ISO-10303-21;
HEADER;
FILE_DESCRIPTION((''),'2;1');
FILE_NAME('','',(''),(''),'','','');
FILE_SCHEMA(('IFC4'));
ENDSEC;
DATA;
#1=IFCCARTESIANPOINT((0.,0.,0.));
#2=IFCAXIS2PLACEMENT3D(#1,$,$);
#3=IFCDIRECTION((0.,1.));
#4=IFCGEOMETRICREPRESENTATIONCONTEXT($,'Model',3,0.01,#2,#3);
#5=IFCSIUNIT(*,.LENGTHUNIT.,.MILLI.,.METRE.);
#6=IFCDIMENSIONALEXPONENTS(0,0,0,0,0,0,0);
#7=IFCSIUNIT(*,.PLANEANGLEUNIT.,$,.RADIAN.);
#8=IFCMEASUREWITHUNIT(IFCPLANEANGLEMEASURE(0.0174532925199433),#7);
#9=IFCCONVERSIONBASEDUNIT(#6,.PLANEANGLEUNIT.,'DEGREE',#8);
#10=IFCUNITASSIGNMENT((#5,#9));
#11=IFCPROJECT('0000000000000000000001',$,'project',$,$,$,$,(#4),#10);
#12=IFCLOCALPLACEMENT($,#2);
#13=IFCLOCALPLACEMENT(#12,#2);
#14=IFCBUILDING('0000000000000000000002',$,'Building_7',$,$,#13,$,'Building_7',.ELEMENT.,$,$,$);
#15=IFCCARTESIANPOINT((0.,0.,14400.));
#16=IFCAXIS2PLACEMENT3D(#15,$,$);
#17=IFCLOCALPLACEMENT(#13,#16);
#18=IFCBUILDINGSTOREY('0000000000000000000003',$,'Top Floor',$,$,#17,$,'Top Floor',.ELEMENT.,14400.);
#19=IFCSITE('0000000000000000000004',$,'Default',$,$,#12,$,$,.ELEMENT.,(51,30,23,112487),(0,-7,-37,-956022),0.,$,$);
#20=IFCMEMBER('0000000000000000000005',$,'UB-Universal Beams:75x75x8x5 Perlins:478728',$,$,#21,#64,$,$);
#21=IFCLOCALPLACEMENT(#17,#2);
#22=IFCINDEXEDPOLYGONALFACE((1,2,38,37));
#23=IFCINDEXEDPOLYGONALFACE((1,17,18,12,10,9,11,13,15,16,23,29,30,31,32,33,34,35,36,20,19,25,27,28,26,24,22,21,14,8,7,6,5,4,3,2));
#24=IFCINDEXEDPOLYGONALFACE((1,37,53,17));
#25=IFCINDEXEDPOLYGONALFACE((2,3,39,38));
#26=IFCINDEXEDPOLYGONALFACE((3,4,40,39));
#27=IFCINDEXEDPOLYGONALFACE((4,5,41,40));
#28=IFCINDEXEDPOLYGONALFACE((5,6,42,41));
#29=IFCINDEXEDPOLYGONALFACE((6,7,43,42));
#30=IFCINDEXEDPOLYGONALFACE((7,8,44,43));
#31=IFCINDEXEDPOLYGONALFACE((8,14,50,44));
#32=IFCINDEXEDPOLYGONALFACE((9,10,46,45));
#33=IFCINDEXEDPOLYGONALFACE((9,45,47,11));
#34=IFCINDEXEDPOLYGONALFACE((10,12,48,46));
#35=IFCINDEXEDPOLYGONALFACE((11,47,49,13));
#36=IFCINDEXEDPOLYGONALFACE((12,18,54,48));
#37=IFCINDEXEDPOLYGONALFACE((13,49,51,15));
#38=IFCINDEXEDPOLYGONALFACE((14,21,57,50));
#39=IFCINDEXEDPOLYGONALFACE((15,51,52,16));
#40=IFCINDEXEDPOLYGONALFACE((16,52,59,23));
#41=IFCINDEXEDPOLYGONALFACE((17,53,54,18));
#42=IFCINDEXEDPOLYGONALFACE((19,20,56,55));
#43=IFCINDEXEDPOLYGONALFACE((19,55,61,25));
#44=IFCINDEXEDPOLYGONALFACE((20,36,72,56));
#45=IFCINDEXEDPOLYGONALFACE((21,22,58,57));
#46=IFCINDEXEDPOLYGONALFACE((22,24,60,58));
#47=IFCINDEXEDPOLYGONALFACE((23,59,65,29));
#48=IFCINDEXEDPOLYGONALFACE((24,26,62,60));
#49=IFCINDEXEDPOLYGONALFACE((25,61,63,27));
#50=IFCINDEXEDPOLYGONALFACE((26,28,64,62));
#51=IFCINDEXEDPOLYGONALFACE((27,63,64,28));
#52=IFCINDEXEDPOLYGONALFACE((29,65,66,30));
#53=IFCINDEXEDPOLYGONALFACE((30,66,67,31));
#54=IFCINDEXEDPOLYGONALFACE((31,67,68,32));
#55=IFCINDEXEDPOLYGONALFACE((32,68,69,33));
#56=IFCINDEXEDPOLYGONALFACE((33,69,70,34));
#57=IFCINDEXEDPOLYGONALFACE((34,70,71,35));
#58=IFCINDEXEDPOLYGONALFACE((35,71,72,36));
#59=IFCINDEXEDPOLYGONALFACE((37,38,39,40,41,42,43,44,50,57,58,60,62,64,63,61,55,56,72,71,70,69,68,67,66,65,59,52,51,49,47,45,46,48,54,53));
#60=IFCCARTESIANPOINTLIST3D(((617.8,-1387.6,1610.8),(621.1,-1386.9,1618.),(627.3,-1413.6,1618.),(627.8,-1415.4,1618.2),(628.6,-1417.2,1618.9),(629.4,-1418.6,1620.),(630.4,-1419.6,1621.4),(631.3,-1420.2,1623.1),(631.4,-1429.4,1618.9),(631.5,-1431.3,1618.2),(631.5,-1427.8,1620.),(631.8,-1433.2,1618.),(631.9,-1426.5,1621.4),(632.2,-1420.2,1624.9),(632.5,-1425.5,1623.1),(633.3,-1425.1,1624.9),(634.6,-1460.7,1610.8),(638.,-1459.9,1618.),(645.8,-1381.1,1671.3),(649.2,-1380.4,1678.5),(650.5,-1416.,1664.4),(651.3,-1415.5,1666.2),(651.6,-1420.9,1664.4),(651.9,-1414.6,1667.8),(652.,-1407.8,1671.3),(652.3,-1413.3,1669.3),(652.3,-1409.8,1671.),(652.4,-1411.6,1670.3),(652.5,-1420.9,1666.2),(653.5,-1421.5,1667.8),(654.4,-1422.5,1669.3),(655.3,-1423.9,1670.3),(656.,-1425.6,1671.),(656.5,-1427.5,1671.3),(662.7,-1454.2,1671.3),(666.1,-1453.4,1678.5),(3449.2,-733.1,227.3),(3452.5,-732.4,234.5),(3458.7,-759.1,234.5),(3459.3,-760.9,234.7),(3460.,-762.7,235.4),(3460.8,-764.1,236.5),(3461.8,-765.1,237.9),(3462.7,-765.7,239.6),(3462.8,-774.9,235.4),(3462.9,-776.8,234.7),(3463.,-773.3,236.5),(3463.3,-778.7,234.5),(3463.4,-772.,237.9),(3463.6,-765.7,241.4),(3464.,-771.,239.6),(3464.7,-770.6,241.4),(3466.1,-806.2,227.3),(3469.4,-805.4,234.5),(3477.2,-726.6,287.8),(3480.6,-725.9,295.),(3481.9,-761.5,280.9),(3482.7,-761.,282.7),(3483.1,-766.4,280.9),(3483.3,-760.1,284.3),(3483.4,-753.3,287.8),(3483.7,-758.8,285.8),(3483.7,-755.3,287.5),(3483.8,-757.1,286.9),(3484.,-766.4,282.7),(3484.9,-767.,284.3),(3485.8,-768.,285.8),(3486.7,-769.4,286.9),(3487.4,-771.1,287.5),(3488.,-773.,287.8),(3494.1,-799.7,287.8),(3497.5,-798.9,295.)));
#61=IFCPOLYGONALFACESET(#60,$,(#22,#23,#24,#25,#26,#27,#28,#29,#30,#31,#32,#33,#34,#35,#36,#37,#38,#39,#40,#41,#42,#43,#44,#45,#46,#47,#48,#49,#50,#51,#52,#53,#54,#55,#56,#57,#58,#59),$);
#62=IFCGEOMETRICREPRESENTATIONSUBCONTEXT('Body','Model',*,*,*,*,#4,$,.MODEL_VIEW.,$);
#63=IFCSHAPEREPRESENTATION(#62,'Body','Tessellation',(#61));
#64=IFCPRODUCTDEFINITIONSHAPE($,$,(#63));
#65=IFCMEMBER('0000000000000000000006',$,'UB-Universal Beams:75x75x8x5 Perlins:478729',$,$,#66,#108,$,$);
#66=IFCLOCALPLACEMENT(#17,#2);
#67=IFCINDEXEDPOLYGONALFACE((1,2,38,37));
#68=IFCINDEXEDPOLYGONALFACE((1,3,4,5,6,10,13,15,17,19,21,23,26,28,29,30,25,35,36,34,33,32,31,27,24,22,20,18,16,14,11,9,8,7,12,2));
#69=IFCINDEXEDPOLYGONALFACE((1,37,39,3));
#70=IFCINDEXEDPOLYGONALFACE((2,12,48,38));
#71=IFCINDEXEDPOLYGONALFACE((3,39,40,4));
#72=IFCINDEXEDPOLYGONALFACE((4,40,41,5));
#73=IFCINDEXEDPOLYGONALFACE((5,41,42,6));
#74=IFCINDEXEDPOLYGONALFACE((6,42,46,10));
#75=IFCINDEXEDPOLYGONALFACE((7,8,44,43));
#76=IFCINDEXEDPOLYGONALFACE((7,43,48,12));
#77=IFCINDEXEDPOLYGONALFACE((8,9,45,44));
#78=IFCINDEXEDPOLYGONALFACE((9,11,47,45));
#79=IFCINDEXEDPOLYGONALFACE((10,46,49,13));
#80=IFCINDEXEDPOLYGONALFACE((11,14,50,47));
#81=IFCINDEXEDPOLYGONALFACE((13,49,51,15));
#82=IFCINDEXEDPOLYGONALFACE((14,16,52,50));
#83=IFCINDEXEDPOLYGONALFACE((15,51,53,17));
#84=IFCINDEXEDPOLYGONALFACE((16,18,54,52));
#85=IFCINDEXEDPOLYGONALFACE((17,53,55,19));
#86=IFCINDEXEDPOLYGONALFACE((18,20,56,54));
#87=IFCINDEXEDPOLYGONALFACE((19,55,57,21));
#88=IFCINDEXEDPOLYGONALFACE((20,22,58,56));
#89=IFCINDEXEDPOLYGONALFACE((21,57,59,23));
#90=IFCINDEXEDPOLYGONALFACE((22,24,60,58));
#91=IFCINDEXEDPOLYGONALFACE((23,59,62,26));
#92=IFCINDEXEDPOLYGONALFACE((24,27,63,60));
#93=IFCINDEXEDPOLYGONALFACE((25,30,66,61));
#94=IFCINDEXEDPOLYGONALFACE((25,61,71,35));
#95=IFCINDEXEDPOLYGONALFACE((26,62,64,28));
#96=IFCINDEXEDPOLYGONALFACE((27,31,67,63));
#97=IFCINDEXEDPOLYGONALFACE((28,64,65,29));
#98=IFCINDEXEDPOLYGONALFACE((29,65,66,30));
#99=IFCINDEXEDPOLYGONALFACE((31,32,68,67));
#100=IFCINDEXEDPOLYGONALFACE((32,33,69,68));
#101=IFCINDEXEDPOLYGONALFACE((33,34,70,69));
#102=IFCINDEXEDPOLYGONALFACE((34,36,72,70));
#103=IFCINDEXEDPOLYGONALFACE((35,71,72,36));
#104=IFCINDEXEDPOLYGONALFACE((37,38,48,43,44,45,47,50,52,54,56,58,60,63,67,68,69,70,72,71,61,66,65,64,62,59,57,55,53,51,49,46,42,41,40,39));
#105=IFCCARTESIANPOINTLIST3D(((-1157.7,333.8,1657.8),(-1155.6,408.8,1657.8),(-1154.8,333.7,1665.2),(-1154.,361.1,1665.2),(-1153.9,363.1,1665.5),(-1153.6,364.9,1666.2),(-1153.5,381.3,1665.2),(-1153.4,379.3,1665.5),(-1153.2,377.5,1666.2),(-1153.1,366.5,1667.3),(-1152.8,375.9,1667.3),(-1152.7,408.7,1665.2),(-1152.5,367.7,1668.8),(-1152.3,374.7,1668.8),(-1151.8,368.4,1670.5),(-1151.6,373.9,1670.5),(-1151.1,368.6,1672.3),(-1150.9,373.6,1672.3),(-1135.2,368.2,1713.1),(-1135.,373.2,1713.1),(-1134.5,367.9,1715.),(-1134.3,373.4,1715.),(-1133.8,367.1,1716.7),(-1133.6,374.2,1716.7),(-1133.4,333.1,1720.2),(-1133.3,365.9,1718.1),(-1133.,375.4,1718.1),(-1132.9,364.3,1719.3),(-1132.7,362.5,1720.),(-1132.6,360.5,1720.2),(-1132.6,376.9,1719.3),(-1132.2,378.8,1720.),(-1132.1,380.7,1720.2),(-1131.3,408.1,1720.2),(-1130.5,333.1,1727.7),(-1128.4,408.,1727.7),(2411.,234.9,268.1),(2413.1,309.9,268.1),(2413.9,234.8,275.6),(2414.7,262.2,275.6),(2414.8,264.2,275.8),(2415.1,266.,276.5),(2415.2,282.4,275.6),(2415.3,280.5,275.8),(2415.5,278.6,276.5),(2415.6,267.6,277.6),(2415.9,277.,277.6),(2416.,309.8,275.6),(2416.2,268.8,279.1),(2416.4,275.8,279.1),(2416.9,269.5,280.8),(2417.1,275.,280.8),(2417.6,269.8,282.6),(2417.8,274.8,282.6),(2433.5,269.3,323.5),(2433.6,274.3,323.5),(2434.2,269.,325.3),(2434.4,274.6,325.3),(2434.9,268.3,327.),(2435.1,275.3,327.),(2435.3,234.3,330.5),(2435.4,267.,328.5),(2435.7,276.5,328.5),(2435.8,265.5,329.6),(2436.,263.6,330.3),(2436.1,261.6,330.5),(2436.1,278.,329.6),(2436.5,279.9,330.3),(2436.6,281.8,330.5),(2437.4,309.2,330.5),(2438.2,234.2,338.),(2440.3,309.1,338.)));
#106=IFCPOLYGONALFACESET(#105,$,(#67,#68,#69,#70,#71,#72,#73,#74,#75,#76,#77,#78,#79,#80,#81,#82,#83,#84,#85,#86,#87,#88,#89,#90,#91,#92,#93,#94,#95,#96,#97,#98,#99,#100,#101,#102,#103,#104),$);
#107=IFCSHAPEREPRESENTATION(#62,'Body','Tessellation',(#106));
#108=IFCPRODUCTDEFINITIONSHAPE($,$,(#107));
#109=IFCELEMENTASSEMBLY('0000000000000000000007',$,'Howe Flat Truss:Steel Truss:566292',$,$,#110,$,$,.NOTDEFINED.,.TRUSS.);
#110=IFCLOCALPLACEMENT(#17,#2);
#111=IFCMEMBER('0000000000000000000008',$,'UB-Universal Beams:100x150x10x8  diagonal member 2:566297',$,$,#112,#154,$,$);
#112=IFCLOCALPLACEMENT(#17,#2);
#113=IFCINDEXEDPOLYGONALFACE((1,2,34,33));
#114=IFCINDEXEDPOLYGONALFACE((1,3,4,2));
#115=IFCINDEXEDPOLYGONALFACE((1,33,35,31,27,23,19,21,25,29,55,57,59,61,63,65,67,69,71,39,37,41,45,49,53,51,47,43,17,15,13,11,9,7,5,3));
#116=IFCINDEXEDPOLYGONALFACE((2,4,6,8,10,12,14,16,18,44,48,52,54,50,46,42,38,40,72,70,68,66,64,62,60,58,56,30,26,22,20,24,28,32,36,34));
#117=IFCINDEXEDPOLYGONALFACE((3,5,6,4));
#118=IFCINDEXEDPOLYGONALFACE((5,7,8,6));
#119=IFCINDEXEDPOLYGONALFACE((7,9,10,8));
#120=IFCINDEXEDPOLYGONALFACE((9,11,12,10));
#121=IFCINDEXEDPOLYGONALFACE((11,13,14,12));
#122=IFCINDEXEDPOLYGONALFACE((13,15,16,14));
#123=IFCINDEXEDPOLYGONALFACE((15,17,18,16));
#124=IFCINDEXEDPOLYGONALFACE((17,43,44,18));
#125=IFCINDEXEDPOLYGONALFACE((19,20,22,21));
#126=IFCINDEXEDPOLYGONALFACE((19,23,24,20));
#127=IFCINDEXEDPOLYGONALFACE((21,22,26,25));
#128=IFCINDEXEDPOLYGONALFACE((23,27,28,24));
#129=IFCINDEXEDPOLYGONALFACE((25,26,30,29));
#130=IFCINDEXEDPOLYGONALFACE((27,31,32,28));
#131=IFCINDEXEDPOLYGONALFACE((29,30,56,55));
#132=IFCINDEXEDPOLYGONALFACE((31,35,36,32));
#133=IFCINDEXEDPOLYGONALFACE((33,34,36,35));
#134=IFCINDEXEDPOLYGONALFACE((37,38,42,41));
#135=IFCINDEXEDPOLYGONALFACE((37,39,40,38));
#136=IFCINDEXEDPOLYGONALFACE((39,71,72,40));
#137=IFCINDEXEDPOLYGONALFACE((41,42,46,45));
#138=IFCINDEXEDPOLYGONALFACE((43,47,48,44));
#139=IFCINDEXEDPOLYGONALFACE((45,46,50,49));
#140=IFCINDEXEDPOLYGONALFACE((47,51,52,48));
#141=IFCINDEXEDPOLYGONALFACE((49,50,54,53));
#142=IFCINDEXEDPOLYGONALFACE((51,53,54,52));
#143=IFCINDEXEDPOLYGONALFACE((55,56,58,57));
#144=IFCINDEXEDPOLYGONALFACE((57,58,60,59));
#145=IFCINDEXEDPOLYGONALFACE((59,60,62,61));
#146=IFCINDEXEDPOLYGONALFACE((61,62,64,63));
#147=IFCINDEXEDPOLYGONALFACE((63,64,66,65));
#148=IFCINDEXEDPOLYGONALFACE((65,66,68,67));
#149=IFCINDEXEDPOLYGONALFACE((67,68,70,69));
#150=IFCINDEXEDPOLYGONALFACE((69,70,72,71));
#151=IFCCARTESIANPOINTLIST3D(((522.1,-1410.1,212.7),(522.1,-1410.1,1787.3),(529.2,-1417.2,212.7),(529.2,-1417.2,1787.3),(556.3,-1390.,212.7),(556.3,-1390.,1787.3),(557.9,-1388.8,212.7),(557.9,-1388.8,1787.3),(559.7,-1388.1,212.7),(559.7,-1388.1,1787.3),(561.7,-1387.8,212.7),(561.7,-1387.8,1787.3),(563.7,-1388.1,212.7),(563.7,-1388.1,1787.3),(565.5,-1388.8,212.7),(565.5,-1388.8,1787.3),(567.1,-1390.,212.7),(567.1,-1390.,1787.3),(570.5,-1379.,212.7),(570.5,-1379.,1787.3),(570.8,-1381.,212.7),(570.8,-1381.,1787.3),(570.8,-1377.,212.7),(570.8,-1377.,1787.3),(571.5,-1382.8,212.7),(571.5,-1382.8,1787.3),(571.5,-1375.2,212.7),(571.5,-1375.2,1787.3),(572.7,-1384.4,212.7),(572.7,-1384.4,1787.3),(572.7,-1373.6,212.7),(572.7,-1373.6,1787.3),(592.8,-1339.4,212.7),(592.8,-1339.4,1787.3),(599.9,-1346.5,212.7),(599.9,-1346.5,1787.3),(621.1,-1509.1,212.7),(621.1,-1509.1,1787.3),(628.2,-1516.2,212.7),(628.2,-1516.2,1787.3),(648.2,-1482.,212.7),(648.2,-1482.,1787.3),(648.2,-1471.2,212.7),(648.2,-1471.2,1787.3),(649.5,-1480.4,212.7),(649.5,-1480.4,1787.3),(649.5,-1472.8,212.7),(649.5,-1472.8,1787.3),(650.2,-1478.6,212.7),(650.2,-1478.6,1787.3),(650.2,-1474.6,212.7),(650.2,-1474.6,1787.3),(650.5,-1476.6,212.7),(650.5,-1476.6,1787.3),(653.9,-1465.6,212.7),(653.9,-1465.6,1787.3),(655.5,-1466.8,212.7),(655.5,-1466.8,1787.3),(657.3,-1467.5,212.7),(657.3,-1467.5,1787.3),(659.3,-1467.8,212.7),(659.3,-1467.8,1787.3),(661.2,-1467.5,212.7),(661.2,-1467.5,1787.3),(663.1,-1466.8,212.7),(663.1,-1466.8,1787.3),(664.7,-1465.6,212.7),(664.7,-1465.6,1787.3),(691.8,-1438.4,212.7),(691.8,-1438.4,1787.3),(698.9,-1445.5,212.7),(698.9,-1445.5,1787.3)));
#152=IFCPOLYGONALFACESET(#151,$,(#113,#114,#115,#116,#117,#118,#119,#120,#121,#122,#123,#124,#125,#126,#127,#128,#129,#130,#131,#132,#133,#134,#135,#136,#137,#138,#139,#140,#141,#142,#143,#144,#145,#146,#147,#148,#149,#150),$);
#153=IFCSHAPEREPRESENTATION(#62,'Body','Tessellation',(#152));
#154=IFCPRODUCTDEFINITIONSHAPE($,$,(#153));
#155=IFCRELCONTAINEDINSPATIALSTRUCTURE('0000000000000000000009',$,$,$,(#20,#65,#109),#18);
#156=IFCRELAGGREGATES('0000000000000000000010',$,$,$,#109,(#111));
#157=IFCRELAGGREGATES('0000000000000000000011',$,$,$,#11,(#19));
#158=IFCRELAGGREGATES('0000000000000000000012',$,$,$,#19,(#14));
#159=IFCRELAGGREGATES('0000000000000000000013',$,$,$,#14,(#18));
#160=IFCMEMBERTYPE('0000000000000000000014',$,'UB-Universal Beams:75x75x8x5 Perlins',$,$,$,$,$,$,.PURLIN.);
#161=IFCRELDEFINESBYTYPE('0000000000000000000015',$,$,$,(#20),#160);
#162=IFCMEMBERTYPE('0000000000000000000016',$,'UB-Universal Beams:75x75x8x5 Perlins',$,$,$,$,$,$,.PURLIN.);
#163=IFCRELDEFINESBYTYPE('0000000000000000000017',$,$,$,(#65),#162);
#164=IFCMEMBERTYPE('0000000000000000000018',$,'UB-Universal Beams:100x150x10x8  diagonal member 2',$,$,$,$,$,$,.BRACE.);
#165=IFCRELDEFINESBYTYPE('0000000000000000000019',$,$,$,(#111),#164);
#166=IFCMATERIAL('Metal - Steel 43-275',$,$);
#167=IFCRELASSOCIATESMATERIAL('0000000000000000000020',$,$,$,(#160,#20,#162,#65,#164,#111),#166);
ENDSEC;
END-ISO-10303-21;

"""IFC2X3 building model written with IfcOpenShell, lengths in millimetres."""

from ifc_helpers import new_model, entity, si_unit, converted_unit, direction, frame, frame_2d, origin, place, context, subcontext, project, spatial, polyline, circle_curve, parameter, trimmed, segment, composite_curve, outline, extrude, source, transform, mapped, material, type_object, type_shapes, element, aggregate, save


model = new_model("IFC2X3")

# Units and contexts
model_context = context("Model", 3, precision=0.01, world=origin(), true_north=direction((0.0, 1.0)))
body_context = subcontext(model_context, "Body", "Model", "MODEL_VIEW")
ifc_project = project(units=[si_unit("LENGTHUNIT", "METRE", prefix="MILLI"), converted_unit("PLANEANGLEUNIT", "DEGREE", entity("IfcPlaneAngleMeasure", 0.0174532925199433), si_unit("PLANEANGLEUNIT", "RADIAN"), dimensions=[0, 0, 0, 0, 0, 0, 0])], contexts=[model_context])

# Site, building, storey
site_placement = place(None, origin())
site = spatial("IfcSite", under=ifc_project, at=site_placement, Name="Default", CompositionType="ELEMENT", RefLatitude=(51, 30, 23, 112487), RefLongitude=(0, -7, -37, -956022), RefElevation=0.0)
building_placement = place(site_placement, origin())
building = spatial("IfcBuilding", under=site, at=building_placement, Name="Building_7", LongName="Building_7", CompositionType="ELEMENT")
storey_placement = place(building_placement, frame((0.0, 0.0, 14400.0)))
storey = spatial("IfcBuildingStorey", under=building, at=storey_placement, Name="Top Floor", LongName="Top Floor", CompositionType="ELEMENT", Elevation=14400.0)

# Members
ifc_material = material(Name="Metal - Steel 43-275")
member_type_1 = type_object("IfcMemberType", Name="UB-Universal Beams:75x75x8x5 Perlins", PredefinedType="PURLIN", material=ifc_material)
shared_shape_1 = source(origin(), body_context, "Body", "SweptSolid", [
    extrude(outline(composite_curve([segment(polyline([(-37.5, -29.5), (-37.5, -37.5)]), True, "CONTINUOUS"), segment(polyline([(-37.5, -37.5), (37.5, -37.5)]), True, "CONTINUOUS"), segment(polyline([(37.5, -37.5), (37.5, -29.5)]), True, "CONTINUOUS"), segment(polyline([(37.5, -29.5), (10.1, -29.5)]), True, "CONTINUOUS"), segment(trimmed(circle_curve(frame_2d((10.1, -21.9), x_axis=(1.0, 0.0)), 7.6), [parameter(180.0)], [parameter(270.0)], True, "PARAMETER"), False, "CONTINUOUS"), segment(polyline([(2.5, -21.9), (2.5, 21.9)]), True, "CONTINUOUS"), segment(trimmed(circle_curve(frame_2d((10.1, 21.9), x_axis=(1.0, 0.0)), 7.6), [parameter(90.0)], [parameter(180.0)], True, "PARAMETER"), False, "CONTINUOUS"), segment(polyline([(10.1, 29.5), (37.5, 29.5)]), True, "CONTINUOUS"), segment(polyline([(37.5, 29.5), (37.5, 37.5)]), True, "CONTINUOUS"), segment(polyline([(37.5, 37.5), (-37.5, 37.5)]), True, "CONTINUOUS"), segment(polyline([(-37.5, 37.5), (-37.5, 29.5)]), True, "CONTINUOUS"), segment(polyline([(-37.5, 29.5), (-10.1, 29.5)]), True, "CONTINUOUS"), segment(trimmed(circle_curve(frame_2d((-10.1, 21.9), x_axis=(1.0, 0.0)), 7.6), [parameter(360.0)], [parameter(90.0)], True, "PARAMETER"), False, "CONTINUOUS"), segment(polyline([(-2.5, 21.9), (-2.5, -21.9)]), True, "CONTINUOUS"), segment(trimmed(circle_curve(frame_2d((-10.1, -21.9), x_axis=(1.0, 0.0)), 7.6), [parameter(270.0)], [parameter(360.0)], True, "PARAMETER"), False, "CONTINUOUS"), segment(polyline([(-10.1, -29.5), (-37.5, -29.5)]), True, "CONTINUOUS")], self_intersect=False)), frame((-1626.2, 0.0, 0.0), z_axis=(-1.0, 0.0, 0.0), x_axis=(0.0, -1.0, 0.0)), (0.0, 0.0, -1.0), 3218.6),
])
type_shapes(member_type_1, [shared_shape_1])
member_1_placement = place(storey_placement, frame((2072.5, -1089.8, 945.6), z_axis=(0.418799, 0.096807, 0.902904), x_axis=(0.879708, 0.203348, -0.429842)))
element("IfcMember", 1, at=member_1_placement, inside=storey, type_object=member_type_1, material=ifc_material, Name="UB-Universal Beams:75x75x8x5 Perlins:478728", context=body_context, shape_type="MappedRepresentation", body=[
    mapped(shared_shape_1, transform((0.0, 0.0, 0.0), scale=1.0)),
])
member_type_2 = type_object("IfcMemberType", Name="UB-Universal Beams:75x75x8x5 Perlins", PredefinedType="PURLIN", material=ifc_material)
shared_shape_2 = source(origin(), body_context, "Body", "SweptSolid", [
    extrude(outline(composite_curve([segment(polyline([(-37.5, -29.5), (-37.5, -37.5)]), True, "CONTINUOUS"), segment(polyline([(-37.5, -37.5), (37.5, -37.5)]), True, "CONTINUOUS"), segment(polyline([(37.5, -37.5), (37.5, -29.5)]), True, "CONTINUOUS"), segment(polyline([(37.5, -29.5), (10.1, -29.5)]), True, "CONTINUOUS"), segment(trimmed(circle_curve(frame_2d((10.1, -21.9), x_axis=(1.0, 0.0)), 7.6), [parameter(180.0)], [parameter(270.0)], True, "PARAMETER"), False, "CONTINUOUS"), segment(polyline([(2.5, -21.9), (2.5, 21.9)]), True, "CONTINUOUS"), segment(trimmed(circle_curve(frame_2d((10.1, 21.9), x_axis=(1.0, 0.0)), 7.6), [parameter(90.0)], [parameter(180.0)], True, "PARAMETER"), False, "CONTINUOUS"), segment(polyline([(10.1, 29.5), (37.5, 29.5)]), True, "CONTINUOUS"), segment(polyline([(37.5, 29.5), (37.5, 37.5)]), True, "CONTINUOUS"), segment(polyline([(37.5, 37.5), (-37.5, 37.5)]), True, "CONTINUOUS"), segment(polyline([(-37.5, 37.5), (-37.5, 29.5)]), True, "CONTINUOUS"), segment(polyline([(-37.5, 29.5), (-10.1, 29.5)]), True, "CONTINUOUS"), segment(trimmed(circle_curve(frame_2d((-10.1, 21.9), x_axis=(1.0, 0.0)), 7.6), [parameter(360.0)], [parameter(90.0)], True, "PARAMETER"), False, "CONTINUOUS"), segment(polyline([(-2.5, 21.9), (-2.5, -21.9)]), True, "CONTINUOUS"), segment(trimmed(circle_curve(frame_2d((-10.1, -21.9), x_axis=(1.0, 0.0)), 7.6), [parameter(270.0)], [parameter(360.0)], True, "PARAMETER"), False, "CONTINUOUS"), segment(polyline([(-10.1, -29.5), (-37.5, -29.5)]), True, "CONTINUOUS")], self_intersect=False)), frame((-1937.5, 0.0, 0.0), z_axis=(-1.0, 0.0, 0.0), x_axis=(0.0, -1.0, 0.0)), (0.0, 0.0, -1.0), 3831.0),
])
type_shapes(member_type_2, [shared_shape_2])
member_2_placement = place(storey_placement, frame((661.8, 320.9, 989.9), z_axis=(0.362605, -0.010047, 0.931889), x_axis=(0.931531, -0.02581, -0.362745)))
element("IfcMember", 2, at=member_2_placement, inside=storey, type_object=member_type_2, material=ifc_material, Name="UB-Universal Beams:75x75x8x5 Perlins:478729", context=body_context, shape_type="MappedRepresentation", body=[
    mapped(shared_shape_2, transform((0.0, 0.0, 0.0), scale=1.0)),
])

# Element assembly, member
assembly_1_placement = place(storey_placement, origin())
assembly_1 = element("IfcElementAssembly", 3, at=assembly_1_placement, inside=storey, Name="Howe Flat Truss:Steel Truss:566292", AssemblyPlace="NOTDEFINED", PredefinedType="TRUSS")
member_type_3 = type_object("IfcMemberType", Name="UB-Universal Beams:100x150x10x8  diagonal member 2", PredefinedType="BRACE", material=ifc_material)
shared_shape_3 = source(origin(), body_context, "Body", "SweptSolid", [
    extrude(outline(composite_curve([segment(polyline([(-50.0, -65.0), (-50.0, -75.0)]), True, "CONTINUOUS"), segment(polyline([(-50.0, -75.0), (50.0, -75.0)]), True, "CONTINUOUS"), segment(polyline([(50.0, -75.0), (50.0, -65.0)]), True, "CONTINUOUS"), segment(polyline([(50.0, -65.0), (11.6, -65.0)]), True, "CONTINUOUS"), segment(trimmed(circle_curve(frame_2d((11.6, -57.4), x_axis=(1.0, 0.0)), 7.6), [parameter(180.0)], [parameter(270.0)], True, "PARAMETER"), False, "CONTINUOUS"), segment(polyline([(4.0, -57.4), (4.0, 57.4)]), True, "CONTINUOUS"), segment(trimmed(circle_curve(frame_2d((11.6, 57.4), x_axis=(1.0, 0.0)), 7.6), [parameter(90.0)], [parameter(180.0)], True, "PARAMETER"), False, "CONTINUOUS"), segment(polyline([(11.6, 65.0), (50.0, 65.0)]), True, "CONTINUOUS"), segment(polyline([(50.0, 65.0), (50.0, 75.0)]), True, "CONTINUOUS"), segment(polyline([(50.0, 75.0), (-50.0, 75.0)]), True, "CONTINUOUS"), segment(polyline([(-50.0, 75.0), (-50.0, 65.0)]), True, "CONTINUOUS"), segment(polyline([(-50.0, 65.0), (-11.6, 65.0)]), True, "CONTINUOUS"), segment(trimmed(circle_curve(frame_2d((-11.6, 57.4), x_axis=(1.0, 0.0)), 7.6), [parameter(360.0)], [parameter(90.0)], True, "PARAMETER"), False, "CONTINUOUS"), segment(polyline([(-4.0, 57.4), (-4.0, -57.4)]), True, "CONTINUOUS"), segment(trimmed(circle_curve(frame_2d((-11.6, -57.4), x_axis=(1.0, 0.0)), 7.6), [parameter(270.0)], [parameter(360.0)], True, "PARAMETER"), False, "CONTINUOUS"), segment(polyline([(-11.6, -65.0), (-50.0, -65.0)]), True, "CONTINUOUS")], self_intersect=False)), frame((-787.3, 0.0, 0.0), z_axis=(-1.0, 0.0, 0.0), x_axis=(0.0, -1.0, 0.0)), (0.0, 0.0, -1.0), 1574.6),
])
type_shapes(member_type_3, [shared_shape_3])
member_3_placement = place(assembly_1_placement, frame((610.5, -1427.8, 1000.0), z_axis=(-0.707107, 0.707107, 0.0), x_axis=(0.0, 0.0, 1.0)))
member_3 = element("IfcMember", 4, at=member_3_placement, type_object=member_type_3, material=ifc_material, Name="UB-Universal Beams:100x150x10x8  diagonal member 2:566297", context=body_context, shape_type="MappedRepresentation", body=[
    mapped(shared_shape_3, transform((0.0, 0.0, 0.0), scale=1.0)),
])
aggregate(assembly_1, [member_3])

save(model, "model.ifc")
